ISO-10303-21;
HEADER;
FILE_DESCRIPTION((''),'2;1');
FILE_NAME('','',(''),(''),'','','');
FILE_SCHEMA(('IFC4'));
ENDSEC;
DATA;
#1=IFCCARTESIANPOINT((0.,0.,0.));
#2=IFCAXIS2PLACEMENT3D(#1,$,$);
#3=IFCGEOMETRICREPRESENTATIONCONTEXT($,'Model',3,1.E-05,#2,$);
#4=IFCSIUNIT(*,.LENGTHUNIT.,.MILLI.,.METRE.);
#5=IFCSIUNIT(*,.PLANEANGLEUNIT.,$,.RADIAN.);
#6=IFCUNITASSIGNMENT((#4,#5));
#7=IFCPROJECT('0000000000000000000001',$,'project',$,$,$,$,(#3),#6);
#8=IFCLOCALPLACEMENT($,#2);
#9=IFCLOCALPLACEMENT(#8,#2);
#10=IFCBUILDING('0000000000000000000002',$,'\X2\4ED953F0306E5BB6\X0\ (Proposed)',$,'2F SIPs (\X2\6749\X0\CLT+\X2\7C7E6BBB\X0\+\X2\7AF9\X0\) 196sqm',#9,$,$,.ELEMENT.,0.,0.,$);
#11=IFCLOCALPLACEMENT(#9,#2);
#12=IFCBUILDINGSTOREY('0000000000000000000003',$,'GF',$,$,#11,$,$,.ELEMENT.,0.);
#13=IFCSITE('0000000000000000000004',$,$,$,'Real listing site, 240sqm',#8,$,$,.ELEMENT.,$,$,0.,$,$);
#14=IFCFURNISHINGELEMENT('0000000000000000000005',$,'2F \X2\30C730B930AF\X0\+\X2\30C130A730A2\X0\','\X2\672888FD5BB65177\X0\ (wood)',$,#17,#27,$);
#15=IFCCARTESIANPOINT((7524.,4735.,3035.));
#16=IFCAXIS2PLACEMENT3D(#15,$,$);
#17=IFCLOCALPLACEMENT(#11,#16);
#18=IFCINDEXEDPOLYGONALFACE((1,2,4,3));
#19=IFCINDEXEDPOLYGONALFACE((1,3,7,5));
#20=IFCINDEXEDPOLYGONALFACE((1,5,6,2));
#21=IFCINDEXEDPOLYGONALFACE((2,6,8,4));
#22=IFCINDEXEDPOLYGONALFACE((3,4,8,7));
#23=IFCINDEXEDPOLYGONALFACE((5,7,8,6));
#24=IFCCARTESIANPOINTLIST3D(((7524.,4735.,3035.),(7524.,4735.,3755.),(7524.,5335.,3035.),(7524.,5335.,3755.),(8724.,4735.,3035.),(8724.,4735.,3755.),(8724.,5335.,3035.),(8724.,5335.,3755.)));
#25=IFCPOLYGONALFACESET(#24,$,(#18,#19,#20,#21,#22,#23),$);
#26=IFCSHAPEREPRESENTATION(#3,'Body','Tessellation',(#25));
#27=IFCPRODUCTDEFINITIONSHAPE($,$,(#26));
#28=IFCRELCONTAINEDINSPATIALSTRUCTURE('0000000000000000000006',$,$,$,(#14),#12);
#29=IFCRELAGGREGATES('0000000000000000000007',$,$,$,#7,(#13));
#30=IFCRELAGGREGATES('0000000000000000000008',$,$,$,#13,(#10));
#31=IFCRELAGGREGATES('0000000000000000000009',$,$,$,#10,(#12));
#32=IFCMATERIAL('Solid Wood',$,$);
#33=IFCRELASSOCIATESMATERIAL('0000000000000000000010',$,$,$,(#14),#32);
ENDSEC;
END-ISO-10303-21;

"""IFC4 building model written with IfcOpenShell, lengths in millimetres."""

from ifc_helpers import new_model, si_unit, frame, frame_2d, origin, place, context, project, spatial, rectangle, extrude, material, element, save


model = new_model("IFC4")

# Units and contexts
model_context = context("Model", 3, precision=1e-05, world=origin())
ifc_project = project(units=[si_unit("LENGTHUNIT", "METRE", prefix="MILLI"), si_unit("PLANEANGLEUNIT", "RADIAN")], contexts=[model_context])

# Site, building, storey
site_placement = place(None, origin())
site = spatial("IfcSite", under=ifc_project, at=site_placement, ObjectType="Real listing site, 240sqm", CompositionType="ELEMENT", RefElevation=0.0)
building_placement = place(site_placement, origin())
building = spatial("IfcBuilding", under=site, at=building_placement, Name="仙台の家 (Proposed)", ObjectType="2F SIPs (杉CLT+籾殻+竹) 196sqm", CompositionType="ELEMENT", ElevationOfRefHeight=0.0, ElevationOfTerrain=0.0)
storey_placement = place(building_placement, origin())
storey = spatial("IfcBuildingStorey", under=building, at=storey_placement, Name="GF", CompositionType="ELEMENT", Elevation=0.0)

# Shared definitions
ifc_material_1 = material(Name="Solid Wood")

# Furnishing element
furnishing_1_placement = place(storey_placement, frame((7524.0, 4735.0, 3035.0)))
element("IfcFurnishingElement", 1, at=furnishing_1_placement, inside=storey, material=ifc_material_1, Name="2F デスク+チェア", Description="木製家具 (wood)", context=model_context, shape_type="SweptSolid", body=[
    extrude(rectangle(XDim=1200.0, YDim=600.0, at=frame_2d((600.0, 300.0))), frame((7524.0, 4735.0, 3035.0)), (0.0, 0.0, 1.0), 720.0),
])

save(model, "model.ifc")
